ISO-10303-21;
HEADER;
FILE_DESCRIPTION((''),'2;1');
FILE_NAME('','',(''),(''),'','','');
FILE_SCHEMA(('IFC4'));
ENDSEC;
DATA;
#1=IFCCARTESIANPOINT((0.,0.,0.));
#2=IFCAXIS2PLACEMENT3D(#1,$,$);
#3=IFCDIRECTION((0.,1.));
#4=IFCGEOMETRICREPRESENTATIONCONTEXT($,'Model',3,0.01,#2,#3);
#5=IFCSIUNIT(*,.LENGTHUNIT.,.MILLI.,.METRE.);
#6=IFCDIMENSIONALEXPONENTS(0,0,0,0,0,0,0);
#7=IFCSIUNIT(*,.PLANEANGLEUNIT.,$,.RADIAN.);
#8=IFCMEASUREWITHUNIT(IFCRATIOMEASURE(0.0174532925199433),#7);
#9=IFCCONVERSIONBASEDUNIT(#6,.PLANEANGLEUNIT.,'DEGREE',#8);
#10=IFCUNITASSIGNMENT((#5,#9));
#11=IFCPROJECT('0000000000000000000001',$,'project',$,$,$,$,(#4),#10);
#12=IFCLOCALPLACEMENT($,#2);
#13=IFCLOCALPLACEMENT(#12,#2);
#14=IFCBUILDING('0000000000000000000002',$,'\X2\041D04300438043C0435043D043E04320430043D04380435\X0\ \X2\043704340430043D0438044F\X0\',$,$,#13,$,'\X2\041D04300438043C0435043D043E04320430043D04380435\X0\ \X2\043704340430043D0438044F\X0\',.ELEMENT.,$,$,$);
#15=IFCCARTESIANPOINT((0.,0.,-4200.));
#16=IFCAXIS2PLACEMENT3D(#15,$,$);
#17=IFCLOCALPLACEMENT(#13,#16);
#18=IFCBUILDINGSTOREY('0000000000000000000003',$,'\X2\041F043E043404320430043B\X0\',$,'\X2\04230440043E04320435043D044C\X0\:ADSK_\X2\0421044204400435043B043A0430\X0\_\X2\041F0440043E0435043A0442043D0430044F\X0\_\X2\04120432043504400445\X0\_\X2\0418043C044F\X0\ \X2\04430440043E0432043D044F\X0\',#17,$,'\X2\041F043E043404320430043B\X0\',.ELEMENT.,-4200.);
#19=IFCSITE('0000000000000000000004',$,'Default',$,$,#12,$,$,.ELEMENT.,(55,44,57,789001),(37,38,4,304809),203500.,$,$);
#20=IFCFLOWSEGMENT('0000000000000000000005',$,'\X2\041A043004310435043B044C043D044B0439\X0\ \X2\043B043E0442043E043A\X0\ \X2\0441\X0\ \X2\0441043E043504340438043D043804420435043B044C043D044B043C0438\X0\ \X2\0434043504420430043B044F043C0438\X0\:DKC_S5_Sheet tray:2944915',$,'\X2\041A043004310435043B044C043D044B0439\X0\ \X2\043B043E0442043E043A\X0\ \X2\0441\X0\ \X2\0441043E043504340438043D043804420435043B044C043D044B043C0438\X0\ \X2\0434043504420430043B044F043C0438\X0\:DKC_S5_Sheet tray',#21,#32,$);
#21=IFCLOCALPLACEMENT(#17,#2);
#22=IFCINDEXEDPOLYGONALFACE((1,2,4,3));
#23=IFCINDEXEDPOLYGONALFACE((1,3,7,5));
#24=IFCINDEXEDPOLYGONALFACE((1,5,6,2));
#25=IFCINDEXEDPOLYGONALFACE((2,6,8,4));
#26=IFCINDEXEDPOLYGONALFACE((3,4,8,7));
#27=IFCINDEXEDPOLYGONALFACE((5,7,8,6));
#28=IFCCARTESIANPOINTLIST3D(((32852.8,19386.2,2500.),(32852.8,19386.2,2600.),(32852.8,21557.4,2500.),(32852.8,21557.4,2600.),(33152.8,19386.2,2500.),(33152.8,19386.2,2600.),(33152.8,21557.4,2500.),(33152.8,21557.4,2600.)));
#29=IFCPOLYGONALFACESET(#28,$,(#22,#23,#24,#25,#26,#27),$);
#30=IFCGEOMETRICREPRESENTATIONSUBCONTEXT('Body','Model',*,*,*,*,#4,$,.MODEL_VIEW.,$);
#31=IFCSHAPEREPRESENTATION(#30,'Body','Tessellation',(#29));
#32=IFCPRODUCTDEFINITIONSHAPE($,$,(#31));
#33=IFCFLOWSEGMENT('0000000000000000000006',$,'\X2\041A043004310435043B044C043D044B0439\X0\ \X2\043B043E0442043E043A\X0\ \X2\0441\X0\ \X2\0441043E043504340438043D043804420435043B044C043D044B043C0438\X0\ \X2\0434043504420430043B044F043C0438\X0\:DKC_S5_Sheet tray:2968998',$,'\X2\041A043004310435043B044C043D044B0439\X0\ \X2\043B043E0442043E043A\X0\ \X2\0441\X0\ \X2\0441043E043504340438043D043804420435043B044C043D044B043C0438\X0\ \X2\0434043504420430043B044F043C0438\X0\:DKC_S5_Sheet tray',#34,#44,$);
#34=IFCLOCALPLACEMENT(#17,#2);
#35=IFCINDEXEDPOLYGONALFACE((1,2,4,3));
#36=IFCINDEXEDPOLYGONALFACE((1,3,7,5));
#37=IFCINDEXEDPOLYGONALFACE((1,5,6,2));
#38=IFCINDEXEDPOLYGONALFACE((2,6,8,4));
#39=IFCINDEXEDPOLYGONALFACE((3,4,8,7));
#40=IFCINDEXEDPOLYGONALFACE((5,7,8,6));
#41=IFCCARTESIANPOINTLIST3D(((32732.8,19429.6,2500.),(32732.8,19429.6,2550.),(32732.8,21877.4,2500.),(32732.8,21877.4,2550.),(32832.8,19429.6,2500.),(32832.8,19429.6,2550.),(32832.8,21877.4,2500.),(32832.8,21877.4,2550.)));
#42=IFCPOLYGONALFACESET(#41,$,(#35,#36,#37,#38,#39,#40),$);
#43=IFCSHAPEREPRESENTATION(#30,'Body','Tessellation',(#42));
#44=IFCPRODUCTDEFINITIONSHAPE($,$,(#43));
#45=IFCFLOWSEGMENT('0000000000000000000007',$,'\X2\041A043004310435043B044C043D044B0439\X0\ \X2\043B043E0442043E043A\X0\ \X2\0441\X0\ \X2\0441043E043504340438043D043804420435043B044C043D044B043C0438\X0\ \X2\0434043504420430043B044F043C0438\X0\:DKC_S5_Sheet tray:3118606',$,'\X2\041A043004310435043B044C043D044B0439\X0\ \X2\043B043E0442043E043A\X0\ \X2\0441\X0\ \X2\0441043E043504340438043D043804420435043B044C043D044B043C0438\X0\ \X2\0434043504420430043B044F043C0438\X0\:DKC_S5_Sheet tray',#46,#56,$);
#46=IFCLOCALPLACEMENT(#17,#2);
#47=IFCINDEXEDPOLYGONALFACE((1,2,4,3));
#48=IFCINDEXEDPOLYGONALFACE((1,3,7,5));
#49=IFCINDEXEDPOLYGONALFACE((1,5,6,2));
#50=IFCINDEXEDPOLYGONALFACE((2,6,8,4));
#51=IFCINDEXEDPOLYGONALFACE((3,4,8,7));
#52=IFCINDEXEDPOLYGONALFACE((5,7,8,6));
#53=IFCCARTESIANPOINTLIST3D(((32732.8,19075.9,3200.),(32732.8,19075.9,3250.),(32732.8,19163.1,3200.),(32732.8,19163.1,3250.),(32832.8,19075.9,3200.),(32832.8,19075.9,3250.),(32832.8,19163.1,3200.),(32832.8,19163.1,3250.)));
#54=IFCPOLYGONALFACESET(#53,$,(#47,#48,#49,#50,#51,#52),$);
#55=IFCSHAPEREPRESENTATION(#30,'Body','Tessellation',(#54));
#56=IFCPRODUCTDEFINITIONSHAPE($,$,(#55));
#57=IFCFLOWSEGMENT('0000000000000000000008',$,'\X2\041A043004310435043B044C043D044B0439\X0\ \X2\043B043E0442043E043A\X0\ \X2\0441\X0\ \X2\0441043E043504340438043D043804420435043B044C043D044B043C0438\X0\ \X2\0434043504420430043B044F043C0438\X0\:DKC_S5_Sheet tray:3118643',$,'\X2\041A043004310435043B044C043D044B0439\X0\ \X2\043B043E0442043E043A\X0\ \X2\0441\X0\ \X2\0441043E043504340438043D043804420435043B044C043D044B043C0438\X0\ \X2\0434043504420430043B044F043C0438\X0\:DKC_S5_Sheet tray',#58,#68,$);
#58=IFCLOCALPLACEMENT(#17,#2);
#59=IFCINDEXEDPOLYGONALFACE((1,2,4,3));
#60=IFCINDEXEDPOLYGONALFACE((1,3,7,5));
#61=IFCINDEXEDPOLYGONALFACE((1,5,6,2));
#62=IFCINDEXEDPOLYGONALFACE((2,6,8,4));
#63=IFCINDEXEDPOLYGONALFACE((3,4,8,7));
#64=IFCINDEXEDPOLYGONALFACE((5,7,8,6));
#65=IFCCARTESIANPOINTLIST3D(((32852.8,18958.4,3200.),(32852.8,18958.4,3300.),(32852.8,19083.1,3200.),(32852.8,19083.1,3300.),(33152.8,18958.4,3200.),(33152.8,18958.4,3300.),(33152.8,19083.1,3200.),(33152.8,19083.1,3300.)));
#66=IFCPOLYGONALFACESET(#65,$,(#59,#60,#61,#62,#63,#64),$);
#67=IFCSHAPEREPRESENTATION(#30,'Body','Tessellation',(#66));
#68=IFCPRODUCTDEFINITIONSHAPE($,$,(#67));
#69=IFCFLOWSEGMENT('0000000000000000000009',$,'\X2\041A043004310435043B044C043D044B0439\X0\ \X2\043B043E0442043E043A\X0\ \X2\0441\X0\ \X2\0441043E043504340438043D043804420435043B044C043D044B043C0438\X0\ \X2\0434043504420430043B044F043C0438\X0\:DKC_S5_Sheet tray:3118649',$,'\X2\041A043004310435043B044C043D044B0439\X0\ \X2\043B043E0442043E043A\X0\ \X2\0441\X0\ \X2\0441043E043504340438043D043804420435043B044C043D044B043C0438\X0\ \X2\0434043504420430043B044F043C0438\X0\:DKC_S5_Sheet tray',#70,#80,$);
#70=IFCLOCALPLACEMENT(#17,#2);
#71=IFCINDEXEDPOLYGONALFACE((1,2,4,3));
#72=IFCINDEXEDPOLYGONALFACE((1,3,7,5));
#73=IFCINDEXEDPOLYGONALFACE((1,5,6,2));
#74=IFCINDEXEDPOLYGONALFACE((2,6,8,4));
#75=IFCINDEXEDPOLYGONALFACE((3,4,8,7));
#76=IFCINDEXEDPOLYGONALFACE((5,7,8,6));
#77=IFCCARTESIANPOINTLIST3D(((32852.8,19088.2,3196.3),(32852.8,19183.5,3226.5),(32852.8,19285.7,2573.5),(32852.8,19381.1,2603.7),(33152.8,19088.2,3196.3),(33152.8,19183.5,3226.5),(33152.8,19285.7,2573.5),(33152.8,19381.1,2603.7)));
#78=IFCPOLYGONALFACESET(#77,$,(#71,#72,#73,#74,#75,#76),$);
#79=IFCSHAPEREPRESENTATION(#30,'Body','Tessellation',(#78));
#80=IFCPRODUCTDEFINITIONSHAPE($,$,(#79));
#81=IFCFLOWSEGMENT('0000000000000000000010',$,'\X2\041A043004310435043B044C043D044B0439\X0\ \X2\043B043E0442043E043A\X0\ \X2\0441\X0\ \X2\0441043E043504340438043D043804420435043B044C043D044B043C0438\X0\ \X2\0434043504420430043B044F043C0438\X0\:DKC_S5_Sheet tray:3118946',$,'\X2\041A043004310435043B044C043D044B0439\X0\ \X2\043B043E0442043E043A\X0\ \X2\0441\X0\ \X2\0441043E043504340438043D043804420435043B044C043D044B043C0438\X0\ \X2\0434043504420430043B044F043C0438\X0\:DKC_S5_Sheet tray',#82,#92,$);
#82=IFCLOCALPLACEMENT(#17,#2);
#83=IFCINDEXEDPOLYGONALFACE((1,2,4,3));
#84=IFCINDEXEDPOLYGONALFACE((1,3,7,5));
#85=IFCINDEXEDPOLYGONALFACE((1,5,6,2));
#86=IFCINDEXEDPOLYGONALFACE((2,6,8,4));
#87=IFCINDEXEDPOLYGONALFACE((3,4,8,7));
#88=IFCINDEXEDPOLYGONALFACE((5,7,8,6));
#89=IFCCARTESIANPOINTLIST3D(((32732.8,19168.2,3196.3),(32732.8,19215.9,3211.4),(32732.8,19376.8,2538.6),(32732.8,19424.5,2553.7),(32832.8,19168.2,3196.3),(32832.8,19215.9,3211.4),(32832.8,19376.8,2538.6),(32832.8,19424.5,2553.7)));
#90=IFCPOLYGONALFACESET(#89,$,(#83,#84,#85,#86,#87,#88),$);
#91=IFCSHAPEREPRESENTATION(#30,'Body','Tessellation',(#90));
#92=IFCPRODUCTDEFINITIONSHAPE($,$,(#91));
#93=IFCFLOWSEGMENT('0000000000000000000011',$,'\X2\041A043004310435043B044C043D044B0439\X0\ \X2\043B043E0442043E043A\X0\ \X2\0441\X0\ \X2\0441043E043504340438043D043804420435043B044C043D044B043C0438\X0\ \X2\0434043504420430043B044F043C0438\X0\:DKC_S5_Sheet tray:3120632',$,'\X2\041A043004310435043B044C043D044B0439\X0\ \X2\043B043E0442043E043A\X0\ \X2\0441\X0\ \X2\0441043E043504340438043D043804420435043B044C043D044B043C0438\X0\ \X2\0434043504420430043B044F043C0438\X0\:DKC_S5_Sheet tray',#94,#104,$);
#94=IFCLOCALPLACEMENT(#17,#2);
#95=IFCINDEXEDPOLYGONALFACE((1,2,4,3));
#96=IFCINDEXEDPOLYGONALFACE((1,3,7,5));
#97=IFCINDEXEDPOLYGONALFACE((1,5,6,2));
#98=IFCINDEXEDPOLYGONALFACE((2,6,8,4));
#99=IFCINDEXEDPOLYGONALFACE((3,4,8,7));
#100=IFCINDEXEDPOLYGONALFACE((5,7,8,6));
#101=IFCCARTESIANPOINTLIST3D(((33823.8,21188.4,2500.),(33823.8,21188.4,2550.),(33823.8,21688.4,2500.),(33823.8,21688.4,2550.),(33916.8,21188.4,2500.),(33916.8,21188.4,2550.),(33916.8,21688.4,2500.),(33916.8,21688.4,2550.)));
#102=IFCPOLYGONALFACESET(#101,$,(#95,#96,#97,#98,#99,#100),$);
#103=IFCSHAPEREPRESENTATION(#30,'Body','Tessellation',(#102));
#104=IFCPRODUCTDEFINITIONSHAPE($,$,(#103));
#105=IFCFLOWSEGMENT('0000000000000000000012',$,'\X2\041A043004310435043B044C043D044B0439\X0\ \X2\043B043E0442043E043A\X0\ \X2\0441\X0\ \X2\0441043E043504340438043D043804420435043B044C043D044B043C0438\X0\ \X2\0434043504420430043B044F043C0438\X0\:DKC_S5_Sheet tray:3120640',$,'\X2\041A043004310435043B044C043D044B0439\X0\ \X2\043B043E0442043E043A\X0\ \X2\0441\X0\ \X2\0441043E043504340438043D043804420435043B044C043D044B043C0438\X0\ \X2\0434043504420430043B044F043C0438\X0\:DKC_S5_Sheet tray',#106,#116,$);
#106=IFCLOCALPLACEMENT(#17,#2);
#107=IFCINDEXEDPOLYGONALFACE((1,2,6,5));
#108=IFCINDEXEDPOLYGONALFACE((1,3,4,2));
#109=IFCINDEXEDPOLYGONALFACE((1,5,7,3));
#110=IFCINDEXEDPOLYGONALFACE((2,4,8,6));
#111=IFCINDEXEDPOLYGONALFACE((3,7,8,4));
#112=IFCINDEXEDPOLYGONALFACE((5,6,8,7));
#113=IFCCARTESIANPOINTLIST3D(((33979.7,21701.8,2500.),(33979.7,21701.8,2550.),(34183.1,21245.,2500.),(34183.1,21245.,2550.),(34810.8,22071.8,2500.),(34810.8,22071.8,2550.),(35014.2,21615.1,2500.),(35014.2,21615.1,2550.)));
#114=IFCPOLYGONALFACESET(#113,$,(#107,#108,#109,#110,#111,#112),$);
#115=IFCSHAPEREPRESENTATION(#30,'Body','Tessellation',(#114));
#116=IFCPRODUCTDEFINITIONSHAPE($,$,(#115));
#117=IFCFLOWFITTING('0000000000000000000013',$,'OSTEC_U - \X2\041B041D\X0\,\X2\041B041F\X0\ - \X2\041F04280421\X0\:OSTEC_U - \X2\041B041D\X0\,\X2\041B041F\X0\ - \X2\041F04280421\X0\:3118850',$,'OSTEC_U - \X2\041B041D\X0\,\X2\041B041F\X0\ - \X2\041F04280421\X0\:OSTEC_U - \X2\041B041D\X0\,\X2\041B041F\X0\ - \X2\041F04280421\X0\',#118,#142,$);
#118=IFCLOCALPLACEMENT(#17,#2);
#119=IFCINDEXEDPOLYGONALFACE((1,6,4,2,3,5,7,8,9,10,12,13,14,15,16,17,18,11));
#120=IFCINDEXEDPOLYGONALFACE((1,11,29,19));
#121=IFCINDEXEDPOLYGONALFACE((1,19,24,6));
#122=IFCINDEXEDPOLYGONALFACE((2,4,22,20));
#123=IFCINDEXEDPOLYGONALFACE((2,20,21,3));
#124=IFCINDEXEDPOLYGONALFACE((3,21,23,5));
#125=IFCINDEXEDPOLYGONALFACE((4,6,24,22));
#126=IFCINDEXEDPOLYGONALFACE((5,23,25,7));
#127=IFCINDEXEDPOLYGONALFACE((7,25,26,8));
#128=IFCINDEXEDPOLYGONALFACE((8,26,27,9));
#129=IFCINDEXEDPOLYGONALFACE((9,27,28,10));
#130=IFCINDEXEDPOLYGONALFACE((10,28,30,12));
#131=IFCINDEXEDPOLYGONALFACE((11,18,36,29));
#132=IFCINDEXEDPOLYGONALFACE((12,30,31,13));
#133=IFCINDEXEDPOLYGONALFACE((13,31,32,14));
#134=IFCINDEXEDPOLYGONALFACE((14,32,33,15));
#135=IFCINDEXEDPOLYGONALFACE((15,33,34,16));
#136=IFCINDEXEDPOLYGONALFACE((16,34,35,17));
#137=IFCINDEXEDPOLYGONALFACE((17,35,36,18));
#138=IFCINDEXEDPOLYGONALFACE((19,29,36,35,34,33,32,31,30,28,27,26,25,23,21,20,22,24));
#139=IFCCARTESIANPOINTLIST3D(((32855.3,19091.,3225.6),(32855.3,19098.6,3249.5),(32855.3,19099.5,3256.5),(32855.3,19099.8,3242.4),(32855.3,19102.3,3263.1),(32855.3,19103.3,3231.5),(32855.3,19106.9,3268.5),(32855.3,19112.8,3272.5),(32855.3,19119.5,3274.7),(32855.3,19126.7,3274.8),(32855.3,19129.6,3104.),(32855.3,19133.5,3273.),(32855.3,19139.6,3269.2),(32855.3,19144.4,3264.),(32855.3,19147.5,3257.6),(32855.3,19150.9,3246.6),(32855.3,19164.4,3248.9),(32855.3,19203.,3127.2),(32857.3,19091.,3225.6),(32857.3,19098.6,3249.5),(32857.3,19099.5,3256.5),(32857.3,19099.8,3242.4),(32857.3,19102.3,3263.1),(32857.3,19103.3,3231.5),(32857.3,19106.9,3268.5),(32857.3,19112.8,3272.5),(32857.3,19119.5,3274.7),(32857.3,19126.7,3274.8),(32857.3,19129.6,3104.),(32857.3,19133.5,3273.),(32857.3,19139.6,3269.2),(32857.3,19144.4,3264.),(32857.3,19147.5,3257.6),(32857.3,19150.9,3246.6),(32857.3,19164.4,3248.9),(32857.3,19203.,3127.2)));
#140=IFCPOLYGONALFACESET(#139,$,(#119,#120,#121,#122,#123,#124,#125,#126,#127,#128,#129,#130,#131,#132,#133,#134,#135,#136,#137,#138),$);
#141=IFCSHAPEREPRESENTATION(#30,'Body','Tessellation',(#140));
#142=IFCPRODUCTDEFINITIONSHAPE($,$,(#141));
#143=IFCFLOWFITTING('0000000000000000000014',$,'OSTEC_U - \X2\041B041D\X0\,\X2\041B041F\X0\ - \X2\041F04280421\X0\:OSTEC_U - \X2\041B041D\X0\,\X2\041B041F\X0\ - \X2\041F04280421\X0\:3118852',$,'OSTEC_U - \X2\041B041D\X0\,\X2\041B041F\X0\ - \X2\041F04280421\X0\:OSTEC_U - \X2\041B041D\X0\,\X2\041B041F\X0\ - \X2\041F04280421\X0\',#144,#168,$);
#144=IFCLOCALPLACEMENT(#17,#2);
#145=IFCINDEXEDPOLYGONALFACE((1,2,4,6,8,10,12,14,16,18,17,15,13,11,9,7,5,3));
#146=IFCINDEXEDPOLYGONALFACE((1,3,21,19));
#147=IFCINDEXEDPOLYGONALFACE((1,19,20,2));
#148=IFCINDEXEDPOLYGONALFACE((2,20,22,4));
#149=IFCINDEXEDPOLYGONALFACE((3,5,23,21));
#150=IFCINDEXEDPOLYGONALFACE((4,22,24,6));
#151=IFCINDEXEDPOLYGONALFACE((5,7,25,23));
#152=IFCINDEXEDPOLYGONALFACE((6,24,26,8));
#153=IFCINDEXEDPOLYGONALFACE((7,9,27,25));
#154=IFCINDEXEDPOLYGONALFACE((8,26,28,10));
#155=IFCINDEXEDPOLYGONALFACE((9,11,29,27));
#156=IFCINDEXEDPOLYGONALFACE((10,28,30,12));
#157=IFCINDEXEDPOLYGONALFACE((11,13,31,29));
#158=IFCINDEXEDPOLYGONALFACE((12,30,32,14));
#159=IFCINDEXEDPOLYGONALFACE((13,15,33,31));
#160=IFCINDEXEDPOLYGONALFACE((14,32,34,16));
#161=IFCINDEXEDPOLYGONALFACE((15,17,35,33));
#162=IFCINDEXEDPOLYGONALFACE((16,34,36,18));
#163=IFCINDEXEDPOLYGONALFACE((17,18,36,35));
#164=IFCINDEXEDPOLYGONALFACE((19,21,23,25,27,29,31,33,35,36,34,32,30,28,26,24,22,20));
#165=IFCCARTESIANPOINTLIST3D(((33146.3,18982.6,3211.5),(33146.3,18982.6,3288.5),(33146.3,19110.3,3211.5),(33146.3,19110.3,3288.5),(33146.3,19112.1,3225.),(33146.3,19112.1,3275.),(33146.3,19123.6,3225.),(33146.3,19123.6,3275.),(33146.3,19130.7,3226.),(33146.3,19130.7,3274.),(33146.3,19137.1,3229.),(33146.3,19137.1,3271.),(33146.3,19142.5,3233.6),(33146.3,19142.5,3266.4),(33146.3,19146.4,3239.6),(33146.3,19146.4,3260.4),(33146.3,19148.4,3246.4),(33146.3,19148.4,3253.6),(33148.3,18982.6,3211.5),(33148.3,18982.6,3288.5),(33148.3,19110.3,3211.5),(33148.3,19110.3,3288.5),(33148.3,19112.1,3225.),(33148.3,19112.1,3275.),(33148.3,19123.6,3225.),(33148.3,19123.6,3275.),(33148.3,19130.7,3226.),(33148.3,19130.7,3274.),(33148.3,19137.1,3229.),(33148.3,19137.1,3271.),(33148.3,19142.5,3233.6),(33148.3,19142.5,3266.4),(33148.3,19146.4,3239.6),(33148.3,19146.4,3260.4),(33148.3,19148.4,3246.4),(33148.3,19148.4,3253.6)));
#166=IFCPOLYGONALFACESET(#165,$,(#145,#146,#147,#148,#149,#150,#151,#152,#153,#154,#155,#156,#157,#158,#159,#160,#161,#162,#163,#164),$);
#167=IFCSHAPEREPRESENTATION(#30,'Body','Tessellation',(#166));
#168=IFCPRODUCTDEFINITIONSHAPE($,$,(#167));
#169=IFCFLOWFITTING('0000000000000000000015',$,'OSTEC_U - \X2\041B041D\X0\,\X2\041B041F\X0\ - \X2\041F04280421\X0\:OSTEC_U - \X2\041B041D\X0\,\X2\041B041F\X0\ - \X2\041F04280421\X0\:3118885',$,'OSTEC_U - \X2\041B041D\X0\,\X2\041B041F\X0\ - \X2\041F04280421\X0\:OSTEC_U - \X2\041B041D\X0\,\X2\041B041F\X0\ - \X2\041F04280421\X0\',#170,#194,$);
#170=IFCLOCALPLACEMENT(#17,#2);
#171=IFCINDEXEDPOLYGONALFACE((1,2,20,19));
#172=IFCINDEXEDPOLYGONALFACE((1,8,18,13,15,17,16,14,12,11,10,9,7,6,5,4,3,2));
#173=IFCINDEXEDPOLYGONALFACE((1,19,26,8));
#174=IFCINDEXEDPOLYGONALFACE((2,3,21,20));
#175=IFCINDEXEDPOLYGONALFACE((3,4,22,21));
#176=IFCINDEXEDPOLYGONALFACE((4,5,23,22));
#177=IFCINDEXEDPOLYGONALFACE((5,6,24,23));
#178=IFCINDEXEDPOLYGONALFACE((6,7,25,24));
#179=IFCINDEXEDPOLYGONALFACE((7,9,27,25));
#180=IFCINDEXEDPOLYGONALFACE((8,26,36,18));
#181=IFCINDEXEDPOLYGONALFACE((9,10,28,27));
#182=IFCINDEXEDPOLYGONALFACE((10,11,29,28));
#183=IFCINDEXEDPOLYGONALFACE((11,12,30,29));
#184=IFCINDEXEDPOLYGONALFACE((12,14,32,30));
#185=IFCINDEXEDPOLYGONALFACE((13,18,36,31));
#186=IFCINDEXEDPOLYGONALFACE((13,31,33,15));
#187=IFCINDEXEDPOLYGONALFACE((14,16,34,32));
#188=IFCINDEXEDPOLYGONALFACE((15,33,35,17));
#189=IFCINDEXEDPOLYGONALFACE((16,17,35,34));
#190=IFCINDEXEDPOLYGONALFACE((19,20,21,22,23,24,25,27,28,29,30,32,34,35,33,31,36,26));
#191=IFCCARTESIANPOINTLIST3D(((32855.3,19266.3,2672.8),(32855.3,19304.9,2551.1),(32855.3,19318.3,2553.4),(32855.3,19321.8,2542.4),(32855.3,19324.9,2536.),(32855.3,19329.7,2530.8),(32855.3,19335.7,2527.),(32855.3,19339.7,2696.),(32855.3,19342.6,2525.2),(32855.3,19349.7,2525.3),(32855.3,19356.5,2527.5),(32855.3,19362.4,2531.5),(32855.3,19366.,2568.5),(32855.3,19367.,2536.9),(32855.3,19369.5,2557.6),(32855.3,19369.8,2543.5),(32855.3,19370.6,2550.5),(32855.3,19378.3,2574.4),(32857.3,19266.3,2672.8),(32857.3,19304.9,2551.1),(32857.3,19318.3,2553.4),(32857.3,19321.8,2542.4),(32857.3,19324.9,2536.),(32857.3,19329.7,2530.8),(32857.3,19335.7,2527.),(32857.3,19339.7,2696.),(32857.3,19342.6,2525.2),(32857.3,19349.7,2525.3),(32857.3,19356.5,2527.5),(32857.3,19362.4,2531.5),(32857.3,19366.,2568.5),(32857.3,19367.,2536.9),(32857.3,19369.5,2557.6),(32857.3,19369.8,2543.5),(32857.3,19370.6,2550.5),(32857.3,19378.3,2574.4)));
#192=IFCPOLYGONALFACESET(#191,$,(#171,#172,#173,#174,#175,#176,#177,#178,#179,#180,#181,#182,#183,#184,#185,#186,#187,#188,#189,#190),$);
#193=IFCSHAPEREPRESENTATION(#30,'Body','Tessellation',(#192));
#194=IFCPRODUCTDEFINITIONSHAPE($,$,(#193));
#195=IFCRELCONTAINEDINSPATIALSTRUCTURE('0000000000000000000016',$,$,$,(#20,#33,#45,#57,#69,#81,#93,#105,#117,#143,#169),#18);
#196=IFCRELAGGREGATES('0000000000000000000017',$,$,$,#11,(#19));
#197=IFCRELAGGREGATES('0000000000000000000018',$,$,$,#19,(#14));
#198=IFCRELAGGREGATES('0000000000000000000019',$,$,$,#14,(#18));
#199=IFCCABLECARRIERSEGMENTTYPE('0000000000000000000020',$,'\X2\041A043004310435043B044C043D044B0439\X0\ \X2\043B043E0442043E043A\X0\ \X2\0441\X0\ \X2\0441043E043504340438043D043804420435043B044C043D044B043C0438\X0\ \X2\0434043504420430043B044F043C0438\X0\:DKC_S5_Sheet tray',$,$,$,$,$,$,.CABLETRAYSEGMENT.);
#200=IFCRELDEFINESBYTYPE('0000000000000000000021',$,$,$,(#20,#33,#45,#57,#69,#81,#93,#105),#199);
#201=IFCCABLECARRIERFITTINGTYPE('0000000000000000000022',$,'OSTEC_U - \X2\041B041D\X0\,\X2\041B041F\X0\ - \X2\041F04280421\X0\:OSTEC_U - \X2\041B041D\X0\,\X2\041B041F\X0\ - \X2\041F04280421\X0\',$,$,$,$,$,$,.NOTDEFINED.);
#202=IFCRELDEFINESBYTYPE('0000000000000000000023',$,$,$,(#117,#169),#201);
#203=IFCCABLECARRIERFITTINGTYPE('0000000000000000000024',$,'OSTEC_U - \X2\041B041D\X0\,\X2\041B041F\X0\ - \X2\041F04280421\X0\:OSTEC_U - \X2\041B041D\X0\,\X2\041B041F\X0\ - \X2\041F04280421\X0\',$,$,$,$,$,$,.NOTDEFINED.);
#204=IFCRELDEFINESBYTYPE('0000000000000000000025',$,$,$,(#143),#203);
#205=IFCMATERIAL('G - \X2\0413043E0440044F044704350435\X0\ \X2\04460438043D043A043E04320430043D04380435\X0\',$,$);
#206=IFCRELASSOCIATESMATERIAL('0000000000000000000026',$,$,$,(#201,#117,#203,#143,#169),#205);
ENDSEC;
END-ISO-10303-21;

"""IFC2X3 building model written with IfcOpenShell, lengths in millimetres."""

from ifc_helpers import new_model, entity, si_unit, converted_unit, direction, frame, frame_2d, origin, origin_2d_with_axis, place, context, subcontext, project, spatial, polyline, circle_curve, parameter, trimmed, segment, composite_curve, rectangle, outline, extrude, source, transform, mapped, material, type_object, type_shapes, element, save


model = new_model("IFC2X3")

# Units and contexts
model_context = context("Model", 3, precision=0.01, world=origin(), true_north=direction((0.0, 1.0)))
body_context = subcontext(model_context, "Body", "Model", "MODEL_VIEW")
ifc_project = project(units=[si_unit("LENGTHUNIT", "METRE", prefix="MILLI"), converted_unit("PLANEANGLEUNIT", "DEGREE", entity("IfcRatioMeasure", 0.0174532925199433), si_unit("PLANEANGLEUNIT", "RADIAN"), dimensions=[0, 0, 0, 0, 0, 0, 0])], contexts=[model_context])

# Site, building, storey
site_placement = place(None, origin())
site = spatial("IfcSite", under=ifc_project, at=site_placement, Name="Default", CompositionType="ELEMENT", RefLatitude=(55, 44, 57, 789001), RefLongitude=(37, 38, 4, 304809), RefElevation=203500.0)
building_placement = place(site_placement, origin())
building = spatial("IfcBuilding", under=site, at=building_placement, Name="Наименование здания", LongName="Наименование здания", CompositionType="ELEMENT")
storey_placement = place(building_placement, frame((0.0, 0.0, -4200.0)))
storey = spatial("IfcBuildingStorey", under=building, at=storey_placement, Name="Подвал", ObjectType="Уровень:ADSK_Стрелка_Проектная_Вверх_Имя уровня", LongName="Подвал", CompositionType="ELEMENT", Elevation=-4200.0)

# Flow segments
cable_carrier_segment_type = type_object("IfcCableCarrierSegmentType", Name="Кабельный лоток с соединительными деталями:DKC_S5_Sheet tray", PredefinedType="CABLETRAYSEGMENT")
flow_segment_1_placement = place(storey_placement, frame((32852.8, 19386.2, 2500.0)))
element("IfcFlowSegment", 1, at=flow_segment_1_placement, inside=storey, type_object=cable_carrier_segment_type, Name="Кабельный лоток с соединительными деталями:DKC_S5_Sheet tray:2944915", ObjectType="Кабельный лоток с соединительными деталями:DKC_S5_Sheet tray", context=body_context, shape_type="SweptSolid", body=[
    extrude(rectangle(XDim=2171.3, YDim=300.0, at=origin_2d_with_axis()), frame((150.0, 1085.6, 0.0), z_axis=(0.0, 0.0, 1.0), x_axis=(0.0, -1.0, 0.0)), (0.0, 0.0, 1.0), 100.0),
])
flow_segment_2_placement = place(storey_placement, frame((32732.8, 19429.6, 2500.0)))
element("IfcFlowSegment", 2, at=flow_segment_2_placement, inside=storey, type_object=cable_carrier_segment_type, Name="Кабельный лоток с соединительными деталями:DKC_S5_Sheet tray:2968998", ObjectType="Кабельный лоток с соединительными деталями:DKC_S5_Sheet tray", context=body_context, shape_type="SweptSolid", body=[
    extrude(rectangle(XDim=2447.9, YDim=100.0, at=origin_2d_with_axis()), frame((50.0, 1223.9, 0.0), z_axis=(0.0, 0.0, 1.0), x_axis=(0.0, -1.0, 0.0)), (0.0, 0.0, 1.0), 50.0),
])
flow_segment_3_placement = place(storey_placement, frame((32732.8, 19075.9, 3200.0)))
element("IfcFlowSegment", 3, at=flow_segment_3_placement, inside=storey, type_object=cable_carrier_segment_type, Name="Кабельный лоток с соединительными деталями:DKC_S5_Sheet tray:3118606", ObjectType="Кабельный лоток с соединительными деталями:DKC_S5_Sheet tray", context=body_context, shape_type="SweptSolid", body=[
    extrude(rectangle(XDim=87.2, YDim=100.0, at=origin_2d_with_axis()), frame((50.0, 43.6, 0.0), z_axis=(0.0, 0.0, 1.0), x_axis=(0.0, 1.0, 0.0)), (0.0, 0.0, 1.0), 50.0),
])
flow_segment_4_placement = place(storey_placement, frame((32852.8, 18958.4, 3200.0)))
element("IfcFlowSegment", 4, at=flow_segment_4_placement, inside=storey, type_object=cable_carrier_segment_type, Name="Кабельный лоток с соединительными деталями:DKC_S5_Sheet tray:3118643", ObjectType="Кабельный лоток с соединительными деталями:DKC_S5_Sheet tray", context=body_context, shape_type="SweptSolid", body=[
    extrude(rectangle(XDim=124.7, YDim=300.0, at=origin_2d_with_axis()), frame((150.0, 62.4, 0.0), z_axis=(0.0, 0.0, 1.0), x_axis=(0.0, 1.0, 0.0)), (0.0, 0.0, 1.0), 100.0),
])
flow_segment_5_placement = place(storey_placement, frame((32852.8, 19088.2, 2573.5)))
element("IfcFlowSegment", 5, at=flow_segment_5_placement, inside=storey, type_object=cable_carrier_segment_type, Name="Кабельный лоток с соединительными деталями:DKC_S5_Sheet tray:3118649", ObjectType="Кабельный лоток с соединительными деталями:DKC_S5_Sheet tray", context=body_context, shape_type="SweptSolid", body=[
    extrude(rectangle(XDim=100.0, YDim=300.0, at=origin_2d_with_axis()), frame((150.0, 245.2, 15.1), z_axis=(0.0, -0.302323, 0.953205), x_axis=(0.0, 0.953205, 0.302323)), (0.0, 0.0, 1.0), 653.3),
])
flow_segment_6_placement = place(storey_placement, frame((32732.8, 19168.2, 2538.6)))
element("IfcFlowSegment", 6, at=flow_segment_6_placement, inside=storey, type_object=cable_carrier_segment_type, Name="Кабельный лоток с соединительными деталями:DKC_S5_Sheet tray:3118946", ObjectType="Кабельный лоток с соединительными деталями:DKC_S5_Sheet tray", context=body_context, shape_type="SweptSolid", body=[
    extrude(rectangle(XDim=50.0, YDim=100.0, at=origin_2d_with_axis()), frame((50.0, 232.4, 7.6), z_axis=(0.0, -0.302323, 0.953205), x_axis=(0.0, 0.953205, 0.302323)), (0.0, 0.0, 1.0), 689.9),
])
flow_segment_7_placement = place(storey_placement, frame((33823.8, 21188.4, 2500.0)))
element("IfcFlowSegment", 7, at=flow_segment_7_placement, inside=storey, type_object=cable_carrier_segment_type, Name="Кабельный лоток с соединительными деталями:DKC_S5_Sheet tray:3120632", ObjectType="Кабельный лоток с соединительными деталями:DKC_S5_Sheet tray", context=body_context, shape_type="SweptSolid", body=[
    extrude(rectangle(XDim=93.0, YDim=500.0, at=origin_2d_with_axis()), frame((46.5, 250.0, 0.0)), (0.0, 0.0, 1.0), 50.0),
])
flow_segment_8_placement = place(storey_placement, frame((33979.7, 21245.0, 2500.0)))
element("IfcFlowSegment", 8, at=flow_segment_8_placement, inside=storey, type_object=cable_carrier_segment_type, Name="Кабельный лоток с соединительными деталями:DKC_S5_Sheet tray:3120640", ObjectType="Кабельный лоток с соединительными деталями:DKC_S5_Sheet tray", context=body_context, shape_type="SweptSolid", body=[
    extrude(rectangle(XDim=909.7, YDim=500.0, at=origin_2d_with_axis()), frame((517.2, 413.4, 0.0), z_axis=(0.0, 0.0, 1.0), x_axis=(0.913545, 0.406737, 0.0)), (0.0, 0.0, 1.0), 50.0),
])

# Flow fittings
ifc_material_1 = material(Name="G - Горячее цинкование")
cable_carrier_fitting_type_1 = type_object("IfcCableCarrierFittingType", Name="OSTEC_U - ЛН,ЛП - ПШС:OSTEC_U - ЛН,ЛП - ПШС", PredefinedType="NOTDEFINED", material=ifc_material_1)
shared_shape_1 = source(origin(), body_context, "Body", "SweptSolid", [
    extrude(outline(composite_curve([segment(trimmed(circle_curve(frame_2d((-41.5, 0.0), x_axis=(1.0, 0.0)), 25.0), [parameter(90.0)], [parameter(270.0)], True, "PARAMETER"), True, "CONTINUOUS"), segment(polyline([(-41.5, -25.0), (-30.0, -25.0)]), True, "CONTINUOUS"), segment(polyline([(-30.0, -25.0), (-28.1, -38.5)]), True, "CONTINUOUS"), segment(polyline([(-28.1, -38.5), (99.5, -38.5)]), True, "CONTINUOUS"), segment(polyline([(99.5, -38.5), (99.5, 38.5)]), True, "CONTINUOUS"), segment(polyline([(99.5, 38.5), (-28.1, 38.5)]), True, "CONTINUOUS"), segment(polyline([(-28.1, 38.5), (-30.0, 25.0)]), True, "CONTINUOUS"), segment(polyline([(-30.0, 25.0), (-41.5, 25.0)]), True, "CONTINUOUS")], self_intersect=False)), frame((41.5, 0.0, 0.0), z_axis=(0.0, 0.0, -1.0), x_axis=(1.0, 0.0, 0.0)), (0.0, 0.0, -1.0), 2.0),
])
type_shapes(cable_carrier_fitting_type_1, [shared_shape_1])
flow_fitting_1_placement = place(storey_placement, frame((32857.3, 19123.6, 3250.0), z_axis=(-1.0, 0.0, 0.0), x_axis=(0.0, 0.302323, -0.953205)))
element("IfcFlowFitting", 9, at=flow_fitting_1_placement, inside=storey, type_object=cable_carrier_fitting_type_1, material=ifc_material_1, Name="OSTEC_U - ЛН,ЛП - ПШС:OSTEC_U - ЛН,ЛП - ПШС:3118850", ObjectType="OSTEC_U - ЛН,ЛП - ПШС:OSTEC_U - ЛН,ЛП - ПШС", context=body_context, shape_type="MappedRepresentation", body=[
    mapped(shared_shape_1, transform((0.0, 0.0, 0.0), scale=1.0)),
])
cable_carrier_fitting_type_2 = type_object("IfcCableCarrierFittingType", Name="OSTEC_U - ЛН,ЛП - ПШС:OSTEC_U - ЛН,ЛП - ПШС", PredefinedType="NOTDEFINED", material=ifc_material_1)
type_shapes(cable_carrier_fitting_type_2, [shared_shape_1])
flow_fitting_2_placement = place(storey_placement, frame((33146.3, 19123.6, 3250.0), z_axis=(1.0, 0.0, 0.0), x_axis=(0.0, -1.0, 0.0)))
element("IfcFlowFitting", 10, at=flow_fitting_2_placement, inside=storey, type_object=cable_carrier_fitting_type_2, material=ifc_material_1, Name="OSTEC_U - ЛН,ЛП - ПШС:OSTEC_U - ЛН,ЛП - ПШС:3118852", ObjectType="OSTEC_U - ЛН,ЛП - ПШС:OSTEC_U - ЛН,ЛП - ПШС", context=body_context, shape_type="MappedRepresentation", body=[
    mapped(shared_shape_1, transform((0.0, 0.0, 0.0), scale=1.0)),
])
flow_fitting_3_placement = place(storey_placement, frame((32857.3, 19345.6, 2550.0), z_axis=(-1.0, 0.0, 0.0), x_axis=(0.0, -0.302323, 0.953205)))
element("IfcFlowFitting", 11, at=flow_fitting_3_placement, inside=storey, type_object=cable_carrier_fitting_type_1, material=ifc_material_1, Name="OSTEC_U - ЛН,ЛП - ПШС:OSTEC_U - ЛН,ЛП - ПШС:3118885", ObjectType="OSTEC_U - ЛН,ЛП - ПШС:OSTEC_U - ЛН,ЛП - ПШС", context=body_context, shape_type="MappedRepresentation", body=[
    mapped(shared_shape_1, transform((0.0, 0.0, 0.0), scale=1.0)),
])

save(model, "model.ifc")
